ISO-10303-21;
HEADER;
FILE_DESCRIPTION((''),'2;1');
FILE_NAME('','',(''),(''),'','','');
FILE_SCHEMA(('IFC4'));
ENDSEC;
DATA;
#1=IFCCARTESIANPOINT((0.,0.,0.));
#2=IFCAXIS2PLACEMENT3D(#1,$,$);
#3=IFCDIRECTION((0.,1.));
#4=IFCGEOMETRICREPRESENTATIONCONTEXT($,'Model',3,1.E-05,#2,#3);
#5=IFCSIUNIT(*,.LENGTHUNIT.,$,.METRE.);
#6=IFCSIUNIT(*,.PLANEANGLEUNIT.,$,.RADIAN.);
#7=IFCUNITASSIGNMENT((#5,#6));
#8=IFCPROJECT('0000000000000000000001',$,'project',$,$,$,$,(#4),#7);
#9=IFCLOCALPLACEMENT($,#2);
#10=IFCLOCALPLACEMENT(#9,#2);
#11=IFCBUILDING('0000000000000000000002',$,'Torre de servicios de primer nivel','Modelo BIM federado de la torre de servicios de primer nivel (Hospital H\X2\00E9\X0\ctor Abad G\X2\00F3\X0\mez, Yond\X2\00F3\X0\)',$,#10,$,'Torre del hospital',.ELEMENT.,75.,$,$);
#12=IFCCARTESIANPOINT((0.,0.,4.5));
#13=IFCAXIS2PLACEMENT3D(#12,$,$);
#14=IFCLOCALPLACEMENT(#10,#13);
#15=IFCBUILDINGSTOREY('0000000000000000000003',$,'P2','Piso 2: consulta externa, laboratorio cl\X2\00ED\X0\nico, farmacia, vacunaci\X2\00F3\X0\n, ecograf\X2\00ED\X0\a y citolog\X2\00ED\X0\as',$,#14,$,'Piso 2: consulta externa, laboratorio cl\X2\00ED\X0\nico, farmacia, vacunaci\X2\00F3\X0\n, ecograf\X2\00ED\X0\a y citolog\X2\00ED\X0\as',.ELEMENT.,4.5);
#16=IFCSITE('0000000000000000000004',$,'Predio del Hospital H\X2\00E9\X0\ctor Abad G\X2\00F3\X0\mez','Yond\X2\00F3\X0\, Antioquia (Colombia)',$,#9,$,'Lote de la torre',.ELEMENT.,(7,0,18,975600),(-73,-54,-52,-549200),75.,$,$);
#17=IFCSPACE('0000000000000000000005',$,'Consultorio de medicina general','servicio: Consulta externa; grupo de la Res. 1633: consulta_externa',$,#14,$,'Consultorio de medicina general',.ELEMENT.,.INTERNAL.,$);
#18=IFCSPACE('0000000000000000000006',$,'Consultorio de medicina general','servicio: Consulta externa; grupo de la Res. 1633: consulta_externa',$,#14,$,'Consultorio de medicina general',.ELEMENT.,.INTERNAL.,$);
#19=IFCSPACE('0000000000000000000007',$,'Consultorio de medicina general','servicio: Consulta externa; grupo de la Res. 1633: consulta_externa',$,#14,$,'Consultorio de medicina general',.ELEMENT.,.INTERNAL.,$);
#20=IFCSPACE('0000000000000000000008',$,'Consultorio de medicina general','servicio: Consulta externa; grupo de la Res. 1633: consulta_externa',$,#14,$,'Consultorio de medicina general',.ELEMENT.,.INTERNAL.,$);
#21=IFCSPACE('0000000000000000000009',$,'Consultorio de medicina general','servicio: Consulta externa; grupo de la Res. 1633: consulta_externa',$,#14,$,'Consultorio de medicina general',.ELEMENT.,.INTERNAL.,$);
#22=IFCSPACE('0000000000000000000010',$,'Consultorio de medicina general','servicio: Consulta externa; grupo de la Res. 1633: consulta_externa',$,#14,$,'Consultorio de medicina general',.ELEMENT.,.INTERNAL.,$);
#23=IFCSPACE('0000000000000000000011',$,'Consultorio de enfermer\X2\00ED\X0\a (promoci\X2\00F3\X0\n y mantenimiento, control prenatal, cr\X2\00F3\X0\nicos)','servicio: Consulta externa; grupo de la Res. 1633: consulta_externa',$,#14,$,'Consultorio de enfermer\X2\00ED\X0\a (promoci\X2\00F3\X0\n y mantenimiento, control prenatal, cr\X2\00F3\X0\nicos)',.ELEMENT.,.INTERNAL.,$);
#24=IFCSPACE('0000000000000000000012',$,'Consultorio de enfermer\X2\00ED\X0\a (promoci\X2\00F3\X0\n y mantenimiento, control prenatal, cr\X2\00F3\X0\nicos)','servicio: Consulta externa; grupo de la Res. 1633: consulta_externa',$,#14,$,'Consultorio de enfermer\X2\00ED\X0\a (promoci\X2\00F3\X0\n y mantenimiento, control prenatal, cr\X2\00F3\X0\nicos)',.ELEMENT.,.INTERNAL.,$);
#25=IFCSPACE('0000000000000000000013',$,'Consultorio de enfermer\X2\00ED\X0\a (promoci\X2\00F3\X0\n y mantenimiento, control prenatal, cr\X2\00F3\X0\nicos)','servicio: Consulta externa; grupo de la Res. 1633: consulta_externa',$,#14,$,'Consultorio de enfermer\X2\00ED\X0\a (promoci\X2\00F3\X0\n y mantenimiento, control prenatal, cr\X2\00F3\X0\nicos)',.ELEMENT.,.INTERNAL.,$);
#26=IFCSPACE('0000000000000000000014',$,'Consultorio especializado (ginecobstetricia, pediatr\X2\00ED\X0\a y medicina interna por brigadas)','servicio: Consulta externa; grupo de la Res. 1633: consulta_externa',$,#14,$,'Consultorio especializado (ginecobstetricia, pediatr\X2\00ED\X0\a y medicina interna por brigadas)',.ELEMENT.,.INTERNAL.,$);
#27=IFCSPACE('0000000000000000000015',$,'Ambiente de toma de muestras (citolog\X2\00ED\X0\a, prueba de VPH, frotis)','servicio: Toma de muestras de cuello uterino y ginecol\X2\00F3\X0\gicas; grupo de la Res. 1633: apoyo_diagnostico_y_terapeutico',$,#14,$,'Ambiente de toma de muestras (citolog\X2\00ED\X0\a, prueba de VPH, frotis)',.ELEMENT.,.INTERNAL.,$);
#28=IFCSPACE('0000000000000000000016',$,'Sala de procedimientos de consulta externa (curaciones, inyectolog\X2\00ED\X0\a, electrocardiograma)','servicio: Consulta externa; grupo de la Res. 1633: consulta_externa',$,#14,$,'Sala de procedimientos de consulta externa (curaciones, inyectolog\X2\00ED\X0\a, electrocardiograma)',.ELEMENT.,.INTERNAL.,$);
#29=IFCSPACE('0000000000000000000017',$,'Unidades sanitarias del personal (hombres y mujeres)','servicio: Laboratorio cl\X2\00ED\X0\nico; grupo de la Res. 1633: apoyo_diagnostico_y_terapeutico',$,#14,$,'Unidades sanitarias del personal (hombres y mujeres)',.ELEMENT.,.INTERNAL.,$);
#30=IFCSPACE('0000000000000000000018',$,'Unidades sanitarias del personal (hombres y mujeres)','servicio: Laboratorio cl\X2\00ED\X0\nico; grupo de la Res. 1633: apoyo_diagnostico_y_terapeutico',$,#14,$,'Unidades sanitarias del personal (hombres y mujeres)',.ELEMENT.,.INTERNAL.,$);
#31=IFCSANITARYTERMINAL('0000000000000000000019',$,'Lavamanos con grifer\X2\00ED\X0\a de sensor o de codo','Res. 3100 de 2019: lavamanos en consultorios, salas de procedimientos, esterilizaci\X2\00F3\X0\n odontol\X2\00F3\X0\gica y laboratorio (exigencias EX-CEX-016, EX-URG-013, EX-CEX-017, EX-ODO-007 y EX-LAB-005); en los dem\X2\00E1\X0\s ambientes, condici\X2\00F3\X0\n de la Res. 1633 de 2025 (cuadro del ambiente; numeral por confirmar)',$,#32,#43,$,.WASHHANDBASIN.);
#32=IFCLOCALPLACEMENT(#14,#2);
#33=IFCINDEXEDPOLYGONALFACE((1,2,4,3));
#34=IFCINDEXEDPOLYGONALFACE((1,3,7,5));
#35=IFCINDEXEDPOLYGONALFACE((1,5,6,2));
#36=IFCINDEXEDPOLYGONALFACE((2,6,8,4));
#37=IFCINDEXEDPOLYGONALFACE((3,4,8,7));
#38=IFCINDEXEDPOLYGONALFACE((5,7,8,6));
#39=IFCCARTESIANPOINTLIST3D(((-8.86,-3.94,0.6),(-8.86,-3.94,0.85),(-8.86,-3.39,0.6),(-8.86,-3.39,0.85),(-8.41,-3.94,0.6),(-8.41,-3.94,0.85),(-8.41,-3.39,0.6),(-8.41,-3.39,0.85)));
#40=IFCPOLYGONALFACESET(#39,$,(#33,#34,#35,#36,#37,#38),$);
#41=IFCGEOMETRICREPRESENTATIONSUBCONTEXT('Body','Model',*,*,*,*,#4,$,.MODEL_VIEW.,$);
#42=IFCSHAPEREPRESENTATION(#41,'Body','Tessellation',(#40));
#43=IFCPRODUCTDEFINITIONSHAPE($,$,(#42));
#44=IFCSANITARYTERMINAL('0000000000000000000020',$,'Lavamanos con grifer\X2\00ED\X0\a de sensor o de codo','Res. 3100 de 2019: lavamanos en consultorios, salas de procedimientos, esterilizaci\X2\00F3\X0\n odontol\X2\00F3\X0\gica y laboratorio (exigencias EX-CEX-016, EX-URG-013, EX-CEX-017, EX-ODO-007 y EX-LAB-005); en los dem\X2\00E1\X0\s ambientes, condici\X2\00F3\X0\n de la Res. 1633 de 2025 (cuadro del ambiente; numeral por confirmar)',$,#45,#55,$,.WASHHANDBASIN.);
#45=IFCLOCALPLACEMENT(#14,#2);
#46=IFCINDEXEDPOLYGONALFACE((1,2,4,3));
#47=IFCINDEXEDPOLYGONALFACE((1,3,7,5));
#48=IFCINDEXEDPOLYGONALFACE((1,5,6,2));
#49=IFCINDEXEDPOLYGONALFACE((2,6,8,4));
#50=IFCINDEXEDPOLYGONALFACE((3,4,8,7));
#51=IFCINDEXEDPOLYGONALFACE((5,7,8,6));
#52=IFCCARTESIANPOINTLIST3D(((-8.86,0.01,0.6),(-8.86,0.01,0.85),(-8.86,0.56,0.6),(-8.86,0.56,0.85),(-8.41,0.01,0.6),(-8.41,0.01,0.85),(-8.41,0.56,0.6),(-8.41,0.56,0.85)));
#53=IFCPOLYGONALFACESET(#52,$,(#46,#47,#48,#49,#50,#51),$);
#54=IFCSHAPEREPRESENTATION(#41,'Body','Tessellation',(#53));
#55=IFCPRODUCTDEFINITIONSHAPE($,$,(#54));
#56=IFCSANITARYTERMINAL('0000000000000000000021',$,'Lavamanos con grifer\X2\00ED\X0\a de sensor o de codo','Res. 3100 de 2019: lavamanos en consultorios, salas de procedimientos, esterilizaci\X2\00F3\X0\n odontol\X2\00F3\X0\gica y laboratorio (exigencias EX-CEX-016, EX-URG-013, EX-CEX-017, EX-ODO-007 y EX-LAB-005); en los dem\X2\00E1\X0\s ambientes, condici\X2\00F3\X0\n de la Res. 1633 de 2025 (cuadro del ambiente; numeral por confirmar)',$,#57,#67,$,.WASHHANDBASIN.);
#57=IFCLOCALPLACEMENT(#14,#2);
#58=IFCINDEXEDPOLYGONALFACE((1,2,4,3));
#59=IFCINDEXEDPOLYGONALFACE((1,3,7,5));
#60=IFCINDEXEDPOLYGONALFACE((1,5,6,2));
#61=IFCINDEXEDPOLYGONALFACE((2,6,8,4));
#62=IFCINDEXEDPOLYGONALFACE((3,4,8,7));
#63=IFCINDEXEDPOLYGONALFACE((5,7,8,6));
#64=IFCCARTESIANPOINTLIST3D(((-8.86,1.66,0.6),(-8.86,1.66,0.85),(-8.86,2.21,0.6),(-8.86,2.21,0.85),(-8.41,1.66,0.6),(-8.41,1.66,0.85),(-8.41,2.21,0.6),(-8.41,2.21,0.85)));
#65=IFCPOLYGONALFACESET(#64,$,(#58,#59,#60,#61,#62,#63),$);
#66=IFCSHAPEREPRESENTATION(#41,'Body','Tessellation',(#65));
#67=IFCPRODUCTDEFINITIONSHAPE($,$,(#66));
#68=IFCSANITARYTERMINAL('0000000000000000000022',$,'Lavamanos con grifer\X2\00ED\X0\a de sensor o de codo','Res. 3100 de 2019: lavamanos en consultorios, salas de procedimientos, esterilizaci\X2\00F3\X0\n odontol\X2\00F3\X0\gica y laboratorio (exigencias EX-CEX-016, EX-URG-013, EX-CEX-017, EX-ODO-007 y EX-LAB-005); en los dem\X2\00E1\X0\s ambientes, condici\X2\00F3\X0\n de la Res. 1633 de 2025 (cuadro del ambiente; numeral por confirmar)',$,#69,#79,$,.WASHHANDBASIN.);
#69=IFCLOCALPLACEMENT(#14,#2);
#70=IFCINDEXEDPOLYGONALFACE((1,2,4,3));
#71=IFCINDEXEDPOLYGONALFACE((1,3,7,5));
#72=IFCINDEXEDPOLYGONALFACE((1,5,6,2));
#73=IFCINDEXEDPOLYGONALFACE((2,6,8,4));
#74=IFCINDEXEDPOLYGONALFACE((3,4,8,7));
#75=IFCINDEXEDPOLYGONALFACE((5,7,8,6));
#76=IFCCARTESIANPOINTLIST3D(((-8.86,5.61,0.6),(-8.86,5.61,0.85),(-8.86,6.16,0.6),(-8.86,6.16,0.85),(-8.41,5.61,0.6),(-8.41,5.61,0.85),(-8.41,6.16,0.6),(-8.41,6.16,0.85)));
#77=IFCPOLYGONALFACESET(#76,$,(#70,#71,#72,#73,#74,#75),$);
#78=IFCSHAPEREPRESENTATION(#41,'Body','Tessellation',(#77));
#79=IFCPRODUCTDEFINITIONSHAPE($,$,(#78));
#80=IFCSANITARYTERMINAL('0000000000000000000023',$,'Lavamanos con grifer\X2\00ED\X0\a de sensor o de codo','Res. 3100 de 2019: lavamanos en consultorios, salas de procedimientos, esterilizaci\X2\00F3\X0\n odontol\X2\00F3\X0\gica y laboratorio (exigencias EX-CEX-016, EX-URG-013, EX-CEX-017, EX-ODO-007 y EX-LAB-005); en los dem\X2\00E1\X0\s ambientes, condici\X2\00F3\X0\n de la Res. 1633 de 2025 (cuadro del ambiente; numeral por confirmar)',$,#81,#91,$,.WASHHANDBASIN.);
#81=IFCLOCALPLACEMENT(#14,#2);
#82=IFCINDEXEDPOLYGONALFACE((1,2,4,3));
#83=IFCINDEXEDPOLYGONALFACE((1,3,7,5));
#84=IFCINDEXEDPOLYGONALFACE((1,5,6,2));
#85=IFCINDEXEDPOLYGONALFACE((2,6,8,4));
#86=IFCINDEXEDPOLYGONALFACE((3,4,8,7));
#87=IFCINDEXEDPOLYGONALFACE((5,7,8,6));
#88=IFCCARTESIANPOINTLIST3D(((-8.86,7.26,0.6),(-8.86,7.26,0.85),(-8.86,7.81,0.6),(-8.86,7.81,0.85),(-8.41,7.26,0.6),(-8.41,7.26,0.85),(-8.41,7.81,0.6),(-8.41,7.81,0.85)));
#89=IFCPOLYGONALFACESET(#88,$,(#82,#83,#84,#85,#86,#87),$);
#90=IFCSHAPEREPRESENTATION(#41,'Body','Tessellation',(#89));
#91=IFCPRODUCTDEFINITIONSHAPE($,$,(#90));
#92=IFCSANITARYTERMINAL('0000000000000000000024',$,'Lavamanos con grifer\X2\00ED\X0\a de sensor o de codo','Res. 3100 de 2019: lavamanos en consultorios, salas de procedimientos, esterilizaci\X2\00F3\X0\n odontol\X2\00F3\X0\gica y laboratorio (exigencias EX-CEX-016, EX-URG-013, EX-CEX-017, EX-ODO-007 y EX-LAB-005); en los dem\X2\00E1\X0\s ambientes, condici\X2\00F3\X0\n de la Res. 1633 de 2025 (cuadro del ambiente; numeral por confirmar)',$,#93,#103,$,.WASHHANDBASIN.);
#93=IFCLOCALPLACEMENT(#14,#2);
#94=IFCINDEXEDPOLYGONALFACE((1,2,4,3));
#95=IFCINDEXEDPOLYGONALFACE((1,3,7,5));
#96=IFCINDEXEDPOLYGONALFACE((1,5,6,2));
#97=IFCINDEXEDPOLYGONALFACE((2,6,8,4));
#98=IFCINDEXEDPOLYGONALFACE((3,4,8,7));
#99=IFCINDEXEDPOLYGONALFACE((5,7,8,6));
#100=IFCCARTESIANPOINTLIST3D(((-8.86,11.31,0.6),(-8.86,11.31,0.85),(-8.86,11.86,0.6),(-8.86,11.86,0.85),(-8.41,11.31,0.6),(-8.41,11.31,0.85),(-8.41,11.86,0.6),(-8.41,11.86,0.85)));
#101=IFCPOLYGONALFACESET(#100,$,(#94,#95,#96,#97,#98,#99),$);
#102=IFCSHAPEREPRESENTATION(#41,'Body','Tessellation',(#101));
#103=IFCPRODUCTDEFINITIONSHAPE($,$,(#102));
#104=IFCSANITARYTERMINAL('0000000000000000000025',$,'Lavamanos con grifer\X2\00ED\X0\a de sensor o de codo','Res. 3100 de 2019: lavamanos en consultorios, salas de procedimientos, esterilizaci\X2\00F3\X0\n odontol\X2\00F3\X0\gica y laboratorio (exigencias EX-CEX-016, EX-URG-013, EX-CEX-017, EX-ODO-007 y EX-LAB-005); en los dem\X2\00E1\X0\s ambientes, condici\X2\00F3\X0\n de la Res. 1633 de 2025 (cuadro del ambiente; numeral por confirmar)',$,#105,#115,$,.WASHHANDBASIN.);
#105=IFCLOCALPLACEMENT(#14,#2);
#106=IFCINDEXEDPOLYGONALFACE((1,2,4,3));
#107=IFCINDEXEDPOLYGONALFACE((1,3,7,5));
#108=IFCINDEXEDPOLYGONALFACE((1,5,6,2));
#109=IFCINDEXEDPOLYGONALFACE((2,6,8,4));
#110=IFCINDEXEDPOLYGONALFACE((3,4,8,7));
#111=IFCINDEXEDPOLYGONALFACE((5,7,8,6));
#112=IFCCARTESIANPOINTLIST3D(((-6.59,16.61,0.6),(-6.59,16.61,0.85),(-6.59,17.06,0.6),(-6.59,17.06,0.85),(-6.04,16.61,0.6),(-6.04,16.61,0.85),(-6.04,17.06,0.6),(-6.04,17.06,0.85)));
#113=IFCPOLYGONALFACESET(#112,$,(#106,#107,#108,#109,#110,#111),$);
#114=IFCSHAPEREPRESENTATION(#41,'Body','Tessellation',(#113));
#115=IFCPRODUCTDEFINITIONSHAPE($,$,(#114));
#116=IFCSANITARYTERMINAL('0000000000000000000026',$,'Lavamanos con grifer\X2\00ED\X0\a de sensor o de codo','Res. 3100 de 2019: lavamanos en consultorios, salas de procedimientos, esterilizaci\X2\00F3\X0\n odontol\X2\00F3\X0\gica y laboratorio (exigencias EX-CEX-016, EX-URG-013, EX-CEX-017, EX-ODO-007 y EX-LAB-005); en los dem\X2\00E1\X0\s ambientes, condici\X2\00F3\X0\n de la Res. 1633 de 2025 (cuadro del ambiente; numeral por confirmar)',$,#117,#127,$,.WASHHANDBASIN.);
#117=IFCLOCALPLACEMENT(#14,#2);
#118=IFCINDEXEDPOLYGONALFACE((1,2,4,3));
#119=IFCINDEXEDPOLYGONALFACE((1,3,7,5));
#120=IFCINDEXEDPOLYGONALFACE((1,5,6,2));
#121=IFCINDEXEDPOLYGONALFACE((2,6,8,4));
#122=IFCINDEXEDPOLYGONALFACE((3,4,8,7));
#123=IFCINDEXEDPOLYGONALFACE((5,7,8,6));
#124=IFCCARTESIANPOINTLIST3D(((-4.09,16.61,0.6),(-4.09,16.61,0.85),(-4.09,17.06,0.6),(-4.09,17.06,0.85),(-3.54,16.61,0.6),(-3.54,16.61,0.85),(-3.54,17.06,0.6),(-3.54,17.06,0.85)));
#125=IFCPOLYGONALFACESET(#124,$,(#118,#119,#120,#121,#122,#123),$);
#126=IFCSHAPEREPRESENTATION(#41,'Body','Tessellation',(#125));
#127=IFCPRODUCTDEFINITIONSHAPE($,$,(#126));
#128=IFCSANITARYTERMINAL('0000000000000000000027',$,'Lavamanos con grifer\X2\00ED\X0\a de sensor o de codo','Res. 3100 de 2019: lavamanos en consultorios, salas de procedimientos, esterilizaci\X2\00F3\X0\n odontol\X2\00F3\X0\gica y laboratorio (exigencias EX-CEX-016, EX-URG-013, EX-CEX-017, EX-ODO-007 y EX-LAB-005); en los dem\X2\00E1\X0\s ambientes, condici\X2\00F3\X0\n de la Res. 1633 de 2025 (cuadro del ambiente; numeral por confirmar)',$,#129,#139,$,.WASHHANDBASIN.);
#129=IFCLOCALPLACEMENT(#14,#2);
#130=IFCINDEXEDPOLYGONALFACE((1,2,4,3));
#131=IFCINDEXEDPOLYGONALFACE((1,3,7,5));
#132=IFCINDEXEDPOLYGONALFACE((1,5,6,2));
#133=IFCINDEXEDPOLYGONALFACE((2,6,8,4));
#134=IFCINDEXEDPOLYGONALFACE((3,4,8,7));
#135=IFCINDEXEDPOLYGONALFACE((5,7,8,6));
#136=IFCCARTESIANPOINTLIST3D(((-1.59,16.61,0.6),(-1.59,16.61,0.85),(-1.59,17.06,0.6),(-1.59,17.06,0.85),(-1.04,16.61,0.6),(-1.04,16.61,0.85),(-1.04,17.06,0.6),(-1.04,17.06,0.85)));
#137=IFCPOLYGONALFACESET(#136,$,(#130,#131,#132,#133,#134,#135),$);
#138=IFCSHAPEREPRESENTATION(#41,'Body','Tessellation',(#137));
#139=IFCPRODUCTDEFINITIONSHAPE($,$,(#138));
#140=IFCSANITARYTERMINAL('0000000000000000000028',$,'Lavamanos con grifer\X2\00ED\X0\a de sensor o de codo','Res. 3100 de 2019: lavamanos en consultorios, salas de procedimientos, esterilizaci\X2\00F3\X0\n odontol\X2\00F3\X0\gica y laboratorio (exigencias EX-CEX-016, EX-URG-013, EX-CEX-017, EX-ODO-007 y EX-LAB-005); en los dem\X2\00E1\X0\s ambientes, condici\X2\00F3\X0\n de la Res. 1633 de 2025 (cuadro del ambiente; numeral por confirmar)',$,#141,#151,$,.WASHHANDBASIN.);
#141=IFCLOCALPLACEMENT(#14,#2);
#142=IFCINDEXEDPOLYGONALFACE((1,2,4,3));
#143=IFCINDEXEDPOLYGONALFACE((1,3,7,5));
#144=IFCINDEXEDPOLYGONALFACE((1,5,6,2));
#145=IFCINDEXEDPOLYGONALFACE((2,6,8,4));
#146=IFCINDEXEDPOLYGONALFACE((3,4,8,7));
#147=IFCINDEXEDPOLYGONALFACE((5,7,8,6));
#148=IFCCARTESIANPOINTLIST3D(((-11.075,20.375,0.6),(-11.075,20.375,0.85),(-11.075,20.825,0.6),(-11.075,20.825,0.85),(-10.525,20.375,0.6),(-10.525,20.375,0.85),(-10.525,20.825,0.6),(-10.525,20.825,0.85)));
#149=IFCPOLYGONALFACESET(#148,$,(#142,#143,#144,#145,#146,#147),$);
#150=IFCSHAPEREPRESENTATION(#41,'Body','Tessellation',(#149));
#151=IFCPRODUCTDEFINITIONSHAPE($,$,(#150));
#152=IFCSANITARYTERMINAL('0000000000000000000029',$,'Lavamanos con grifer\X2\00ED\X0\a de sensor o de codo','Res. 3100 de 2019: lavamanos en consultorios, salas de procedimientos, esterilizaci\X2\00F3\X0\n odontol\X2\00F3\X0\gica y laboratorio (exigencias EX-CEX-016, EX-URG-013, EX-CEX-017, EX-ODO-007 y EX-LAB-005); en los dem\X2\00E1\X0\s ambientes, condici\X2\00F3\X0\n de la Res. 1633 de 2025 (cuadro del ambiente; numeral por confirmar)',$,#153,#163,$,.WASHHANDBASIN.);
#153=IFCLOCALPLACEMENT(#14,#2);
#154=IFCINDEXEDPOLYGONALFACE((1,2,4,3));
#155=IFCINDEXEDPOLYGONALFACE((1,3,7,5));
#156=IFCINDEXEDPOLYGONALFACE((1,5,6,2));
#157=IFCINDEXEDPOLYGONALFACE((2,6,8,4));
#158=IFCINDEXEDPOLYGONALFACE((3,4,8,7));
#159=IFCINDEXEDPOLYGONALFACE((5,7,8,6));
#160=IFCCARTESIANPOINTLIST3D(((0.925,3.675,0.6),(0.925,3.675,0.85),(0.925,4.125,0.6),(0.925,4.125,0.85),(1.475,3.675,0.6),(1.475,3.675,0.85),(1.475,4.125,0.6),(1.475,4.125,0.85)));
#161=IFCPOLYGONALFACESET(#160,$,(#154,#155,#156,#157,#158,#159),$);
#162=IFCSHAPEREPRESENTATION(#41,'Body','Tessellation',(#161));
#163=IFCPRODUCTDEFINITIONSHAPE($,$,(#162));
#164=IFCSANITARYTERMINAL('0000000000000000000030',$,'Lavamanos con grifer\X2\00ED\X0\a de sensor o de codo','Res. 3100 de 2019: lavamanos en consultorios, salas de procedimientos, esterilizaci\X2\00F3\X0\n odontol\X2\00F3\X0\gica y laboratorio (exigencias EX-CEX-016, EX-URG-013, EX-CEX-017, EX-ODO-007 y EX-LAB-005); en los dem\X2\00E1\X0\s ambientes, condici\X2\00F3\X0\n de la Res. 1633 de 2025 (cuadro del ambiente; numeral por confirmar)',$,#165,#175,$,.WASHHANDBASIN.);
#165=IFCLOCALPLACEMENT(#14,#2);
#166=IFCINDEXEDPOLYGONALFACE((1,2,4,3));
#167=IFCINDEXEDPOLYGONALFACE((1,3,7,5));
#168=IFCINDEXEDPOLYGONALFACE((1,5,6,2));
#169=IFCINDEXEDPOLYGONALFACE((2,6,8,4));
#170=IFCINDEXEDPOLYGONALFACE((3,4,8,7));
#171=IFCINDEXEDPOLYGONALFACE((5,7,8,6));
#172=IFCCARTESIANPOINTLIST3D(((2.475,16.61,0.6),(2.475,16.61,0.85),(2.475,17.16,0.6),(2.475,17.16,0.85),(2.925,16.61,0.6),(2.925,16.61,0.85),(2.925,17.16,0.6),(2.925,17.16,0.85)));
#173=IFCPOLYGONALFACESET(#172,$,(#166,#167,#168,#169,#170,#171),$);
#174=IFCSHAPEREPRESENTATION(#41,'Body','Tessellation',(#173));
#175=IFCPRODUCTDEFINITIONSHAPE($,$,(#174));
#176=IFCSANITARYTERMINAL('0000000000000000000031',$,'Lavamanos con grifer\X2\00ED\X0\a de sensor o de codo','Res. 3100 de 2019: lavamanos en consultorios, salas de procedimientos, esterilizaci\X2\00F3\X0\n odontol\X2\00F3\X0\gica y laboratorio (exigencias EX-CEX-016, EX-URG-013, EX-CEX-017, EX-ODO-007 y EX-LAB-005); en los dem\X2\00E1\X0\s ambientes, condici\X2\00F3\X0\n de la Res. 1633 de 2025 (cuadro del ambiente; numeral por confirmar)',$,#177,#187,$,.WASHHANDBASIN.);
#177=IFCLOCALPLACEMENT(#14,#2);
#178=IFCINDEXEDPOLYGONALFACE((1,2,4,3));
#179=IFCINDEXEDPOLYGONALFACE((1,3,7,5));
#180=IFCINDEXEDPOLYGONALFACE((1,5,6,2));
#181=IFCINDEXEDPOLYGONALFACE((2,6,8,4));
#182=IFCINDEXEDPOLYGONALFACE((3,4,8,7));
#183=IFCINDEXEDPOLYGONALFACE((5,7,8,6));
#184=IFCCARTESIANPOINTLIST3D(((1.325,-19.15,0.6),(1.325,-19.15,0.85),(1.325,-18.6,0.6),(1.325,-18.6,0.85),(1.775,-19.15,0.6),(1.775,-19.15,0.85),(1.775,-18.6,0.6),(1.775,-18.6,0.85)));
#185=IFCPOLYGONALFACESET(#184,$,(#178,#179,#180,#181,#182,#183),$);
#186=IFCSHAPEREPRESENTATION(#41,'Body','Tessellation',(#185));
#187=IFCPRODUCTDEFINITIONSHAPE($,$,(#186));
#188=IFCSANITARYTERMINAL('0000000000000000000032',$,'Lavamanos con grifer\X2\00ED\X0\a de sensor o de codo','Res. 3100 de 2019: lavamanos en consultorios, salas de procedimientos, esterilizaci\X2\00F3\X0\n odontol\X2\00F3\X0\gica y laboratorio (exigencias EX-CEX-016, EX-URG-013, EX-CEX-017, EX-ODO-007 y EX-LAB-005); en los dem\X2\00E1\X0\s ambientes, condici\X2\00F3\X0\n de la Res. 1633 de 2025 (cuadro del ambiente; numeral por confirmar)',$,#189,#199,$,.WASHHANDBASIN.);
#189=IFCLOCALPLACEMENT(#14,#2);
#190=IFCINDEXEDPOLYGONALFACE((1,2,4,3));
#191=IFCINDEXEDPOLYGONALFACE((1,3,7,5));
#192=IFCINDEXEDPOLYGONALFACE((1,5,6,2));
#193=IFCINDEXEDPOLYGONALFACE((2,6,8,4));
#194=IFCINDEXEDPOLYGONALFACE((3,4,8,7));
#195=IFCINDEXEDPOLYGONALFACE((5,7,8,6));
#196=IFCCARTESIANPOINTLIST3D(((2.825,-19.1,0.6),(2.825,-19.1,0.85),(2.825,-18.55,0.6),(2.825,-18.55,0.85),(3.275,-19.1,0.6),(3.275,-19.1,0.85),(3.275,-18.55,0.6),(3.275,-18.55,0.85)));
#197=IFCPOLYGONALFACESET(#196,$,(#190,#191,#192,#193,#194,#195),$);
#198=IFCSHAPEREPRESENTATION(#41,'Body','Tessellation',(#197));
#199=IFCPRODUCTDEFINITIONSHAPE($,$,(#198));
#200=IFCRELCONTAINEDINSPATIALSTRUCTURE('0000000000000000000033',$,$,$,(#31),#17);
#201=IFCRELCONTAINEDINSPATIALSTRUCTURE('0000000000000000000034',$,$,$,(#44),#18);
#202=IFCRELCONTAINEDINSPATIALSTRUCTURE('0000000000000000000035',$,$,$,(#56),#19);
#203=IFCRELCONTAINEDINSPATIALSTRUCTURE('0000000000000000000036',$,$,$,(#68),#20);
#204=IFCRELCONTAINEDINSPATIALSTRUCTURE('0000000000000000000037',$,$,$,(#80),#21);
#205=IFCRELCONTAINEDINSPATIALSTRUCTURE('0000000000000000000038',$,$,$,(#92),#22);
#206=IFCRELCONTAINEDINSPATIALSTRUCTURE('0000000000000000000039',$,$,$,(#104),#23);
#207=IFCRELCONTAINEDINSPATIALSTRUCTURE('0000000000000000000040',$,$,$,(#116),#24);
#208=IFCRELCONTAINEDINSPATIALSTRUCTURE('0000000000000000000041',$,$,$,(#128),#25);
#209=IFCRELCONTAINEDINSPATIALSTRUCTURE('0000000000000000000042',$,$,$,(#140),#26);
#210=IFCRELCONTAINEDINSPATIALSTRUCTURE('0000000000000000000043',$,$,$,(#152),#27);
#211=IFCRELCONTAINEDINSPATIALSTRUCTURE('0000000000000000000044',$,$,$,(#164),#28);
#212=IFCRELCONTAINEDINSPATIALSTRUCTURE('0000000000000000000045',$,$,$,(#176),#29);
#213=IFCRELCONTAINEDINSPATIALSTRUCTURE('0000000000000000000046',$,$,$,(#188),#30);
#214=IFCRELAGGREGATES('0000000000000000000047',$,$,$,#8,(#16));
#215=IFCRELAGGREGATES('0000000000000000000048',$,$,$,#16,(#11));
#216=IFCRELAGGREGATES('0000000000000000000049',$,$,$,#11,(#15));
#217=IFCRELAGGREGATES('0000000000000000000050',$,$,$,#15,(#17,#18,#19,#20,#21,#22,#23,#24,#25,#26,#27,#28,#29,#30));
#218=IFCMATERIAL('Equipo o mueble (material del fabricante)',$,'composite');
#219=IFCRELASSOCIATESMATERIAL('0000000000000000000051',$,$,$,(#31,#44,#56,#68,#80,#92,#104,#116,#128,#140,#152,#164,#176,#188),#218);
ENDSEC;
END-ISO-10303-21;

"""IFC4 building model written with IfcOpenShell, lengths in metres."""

from ifc_helpers import new_model, si_unit, direction, frame, origin, place, context, subcontext, project, spatial, rectangle, extrude, material, element, save


model = new_model("IFC4")

# Units and contexts
model_context = context("Model", 3, precision=1e-05, world=origin(), true_north=direction((0.0, 1.0)))
body_context = subcontext(model_context, "Body", "Model", "MODEL_VIEW")
ifc_project = project(units=[si_unit("LENGTHUNIT", "METRE"), si_unit("PLANEANGLEUNIT", "RADIAN")], contexts=[model_context])

# Site, building, storey
site_placement = place(None, origin())
site = spatial("IfcSite", under=ifc_project, at=site_placement, Name="Predio del Hospital Héctor Abad Gómez", Description="Yondó, Antioquia (Colombia)", LongName="Lote de la torre", CompositionType="ELEMENT", RefLatitude=(7, 0, 18, 975600), RefLongitude=(-73, -54, -52, -549200), RefElevation=75.0)
building_placement = place(site_placement, origin())
building = spatial("IfcBuilding", under=site, at=building_placement, Name="Torre de servicios de primer nivel", Description="Modelo BIM federado de la torre de servicios de primer nivel (Hospital Héctor Abad Gómez, Yondó)", LongName="Torre del hospital", CompositionType="ELEMENT", ElevationOfRefHeight=75.0)
placement = place(building_placement, frame((0.0, 0.0, 4.5)))
storey = spatial("IfcBuildingStorey", under=building, at=placement, Name="P2", Description="Piso 2: consulta externa, laboratorio clínico, farmacia, vacunación, ecografía y citologías", LongName="Piso 2: consulta externa, laboratorio clínico, farmacia, vacunación, ecografía y citologías", CompositionType="ELEMENT", Elevation=4.5)

# Shared definitions
ifc_material = material(Name="Equipo o mueble (material del fabricante)", Category="composite")

# Shared definitions
space_1 = spatial("IfcSpace", under=storey, at=placement, Name="Consultorio de medicina general", Description="servicio: Consulta externa; grupo de la Res. 1633: consulta_externa", LongName="Consultorio de medicina general", CompositionType="ELEMENT", PredefinedType="INTERNAL")

# Sanitary terminal
element("IfcSanitaryTerminal", 1, at=placement, inside=space_1, material=ifc_material, Name="Lavamanos con grifería de sensor o de codo", Description="Res. 3100 de 2019: lavamanos en consultorios, salas de procedimientos, esterilización odontológica y laboratorio (exigencias EX-CEX-016, EX-URG-013, EX-CEX-017, EX-ODO-007 y EX-LAB-005); en los demás ambientes, condición de la Res. 1633 de 2025 (cuadro del ambiente; numeral por confirmar)", PredefinedType="WASHHANDBASIN", context=body_context, shape_type="SweptSolid", body=[
    extrude(rectangle(XDim=0.55, YDim=0.45), frame((-8.635, -3.665, 0.6), z_axis=(0.0, 0.0, 1.0), x_axis=(0.0, 1.0, 0.0)), (0.0, 0.0, 1.0), 0.25),
])

# Shared definitions
space_2 = spatial("IfcSpace", under=storey, at=placement, Name="Consultorio de medicina general", Description="servicio: Consulta externa; grupo de la Res. 1633: consulta_externa", LongName="Consultorio de medicina general", CompositionType="ELEMENT", PredefinedType="INTERNAL")

# Sanitary terminal
element("IfcSanitaryTerminal", 2, at=placement, inside=space_2, material=ifc_material, Name="Lavamanos con grifería de sensor o de codo", Description="Res. 3100 de 2019: lavamanos en consultorios, salas de procedimientos, esterilización odontológica y laboratorio (exigencias EX-CEX-016, EX-URG-013, EX-CEX-017, EX-ODO-007 y EX-LAB-005); en los demás ambientes, condición de la Res. 1633 de 2025 (cuadro del ambiente; numeral por confirmar)", PredefinedType="WASHHANDBASIN", context=body_context, shape_type="SweptSolid", body=[
    extrude(rectangle(XDim=0.55, YDim=0.45), frame((-8.635, 0.285, 0.6), z_axis=(0.0, 0.0, 1.0), x_axis=(0.0, 1.0, 0.0)), (0.0, 0.0, 1.0), 0.25),
])

# Shared definitions
space_3 = spatial("IfcSpace", under=storey, at=placement, Name="Consultorio de medicina general", Description="servicio: Consulta externa; grupo de la Res. 1633: consulta_externa", LongName="Consultorio de medicina general", CompositionType="ELEMENT", PredefinedType="INTERNAL")

# Sanitary terminal
element("IfcSanitaryTerminal", 3, at=placement, inside=space_3, material=ifc_material, Name="Lavamanos con grifería de sensor o de codo", Description="Res. 3100 de 2019: lavamanos en consultorios, salas de procedimientos, esterilización odontológica y laboratorio (exigencias EX-CEX-016, EX-URG-013, EX-CEX-017, EX-ODO-007 y EX-LAB-005); en los demás ambientes, condición de la Res. 1633 de 2025 (cuadro del ambiente; numeral por confirmar)", PredefinedType="WASHHANDBASIN", context=body_context, shape_type="SweptSolid", body=[
    extrude(rectangle(XDim=0.55, YDim=0.45), frame((-8.635, 1.935, 0.6), z_axis=(0.0, 0.0, 1.0), x_axis=(0.0, 1.0, 0.0)), (0.0, 0.0, 1.0), 0.25),
])

# Shared definitions
space_4 = spatial("IfcSpace", under=storey, at=placement, Name="Consultorio de medicina general", Description="servicio: Consulta externa; grupo de la Res. 1633: consulta_externa", LongName="Consultorio de medicina general", CompositionType="ELEMENT", PredefinedType="INTERNAL")

# Sanitary terminal
element("IfcSanitaryTerminal", 4, at=placement, inside=space_4, material=ifc_material, Name="Lavamanos con grifería de sensor o de codo", Description="Res. 3100 de 2019: lavamanos en consultorios, salas de procedimientos, esterilización odontológica y laboratorio (exigencias EX-CEX-016, EX-URG-013, EX-CEX-017, EX-ODO-007 y EX-LAB-005); en los demás ambientes, condición de la Res. 1633 de 2025 (cuadro del ambiente; numeral por confirmar)", PredefinedType="WASHHANDBASIN", context=body_context, shape_type="SweptSolid", body=[
    extrude(rectangle(XDim=0.55, YDim=0.45), frame((-8.635, 5.885, 0.6), z_axis=(0.0, 0.0, 1.0), x_axis=(0.0, 1.0, 0.0)), (0.0, 0.0, 1.0), 0.25),
])

# Shared definitions
space_5 = spatial("IfcSpace", under=storey, at=placement, Name="Consultorio de medicina general", Description="servicio: Consulta externa; grupo de la Res. 1633: consulta_externa", LongName="Consultorio de medicina general", CompositionType="ELEMENT", PredefinedType="INTERNAL")

# Sanitary terminal
element("IfcSanitaryTerminal", 5, at=placement, inside=space_5, material=ifc_material, Name="Lavamanos con grifería de sensor o de codo", Description="Res. 3100 de 2019: lavamanos en consultorios, salas de procedimientos, esterilización odontológica y laboratorio (exigencias EX-CEX-016, EX-URG-013, EX-CEX-017, EX-ODO-007 y EX-LAB-005); en los demás ambientes, condición de la Res. 1633 de 2025 (cuadro del ambiente; numeral por confirmar)", PredefinedType="WASHHANDBASIN", context=body_context, shape_type="SweptSolid", body=[
    extrude(rectangle(XDim=0.55, YDim=0.45), frame((-8.635, 7.535, 0.6), z_axis=(0.0, 0.0, 1.0), x_axis=(0.0, 1.0, 0.0)), (0.0, 0.0, 1.0), 0.25),
])

# Shared definitions
space_6 = spatial("IfcSpace", under=storey, at=placement, Name="Consultorio de medicina general", Description="servicio: Consulta externa; grupo de la Res. 1633: consulta_externa", LongName="Consultorio de medicina general", CompositionType="ELEMENT", PredefinedType="INTERNAL")

# Sanitary terminal
element("IfcSanitaryTerminal", 6, at=placement, inside=space_6, material=ifc_material, Name="Lavamanos con grifería de sensor o de codo", Description="Res. 3100 de 2019: lavamanos en consultorios, salas de procedimientos, esterilización odontológica y laboratorio (exigencias EX-CEX-016, EX-URG-013, EX-CEX-017, EX-ODO-007 y EX-LAB-005); en los demás ambientes, condición de la Res. 1633 de 2025 (cuadro del ambiente; numeral por confirmar)", PredefinedType="WASHHANDBASIN", context=body_context, shape_type="SweptSolid", body=[
    extrude(rectangle(XDim=0.55, YDim=0.45), frame((-8.635, 11.585, 0.6), z_axis=(0.0, 0.0, 1.0), x_axis=(0.0, 1.0, 0.0)), (0.0, 0.0, 1.0), 0.25),
])

# Shared definitions
space_7 = spatial("IfcSpace", under=storey, at=placement, Name="Consultorio de enfermería (promoción y mantenimiento, control prenatal, crónicos)", Description="servicio: Consulta externa; grupo de la Res. 1633: consulta_externa", LongName="Consultorio de enfermería (promoción y mantenimiento, control prenatal, crónicos)", CompositionType="ELEMENT", PredefinedType="INTERNAL")

# Sanitary terminal
element("IfcSanitaryTerminal", 7, at=placement, inside=space_7, material=ifc_material, Name="Lavamanos con grifería de sensor o de codo", Description="Res. 3100 de 2019: lavamanos en consultorios, salas de procedimientos, esterilización odontológica y laboratorio (exigencias EX-CEX-016, EX-URG-013, EX-CEX-017, EX-ODO-007 y EX-LAB-005); en los demás ambientes, condición de la Res. 1633 de 2025 (cuadro del ambiente; numeral por confirmar)", PredefinedType="WASHHANDBASIN", context=body_context, shape_type="SweptSolid", body=[
    extrude(rectangle(XDim=0.55, YDim=0.45), frame((-6.315, 16.835, 0.6)), (0.0, 0.0, 1.0), 0.25),
])

# Shared definitions
space_8 = spatial("IfcSpace", under=storey, at=placement, Name="Consultorio de enfermería (promoción y mantenimiento, control prenatal, crónicos)", Description="servicio: Consulta externa; grupo de la Res. 1633: consulta_externa", LongName="Consultorio de enfermería (promoción y mantenimiento, control prenatal, crónicos)", CompositionType="ELEMENT", PredefinedType="INTERNAL")

# Sanitary terminal
element("IfcSanitaryTerminal", 8, at=placement, inside=space_8, material=ifc_material, Name="Lavamanos con grifería de sensor o de codo", Description="Res. 3100 de 2019: lavamanos en consultorios, salas de procedimientos, esterilización odontológica y laboratorio (exigencias EX-CEX-016, EX-URG-013, EX-CEX-017, EX-ODO-007 y EX-LAB-005); en los demás ambientes, condición de la Res. 1633 de 2025 (cuadro del ambiente; numeral por confirmar)", PredefinedType="WASHHANDBASIN", context=body_context, shape_type="SweptSolid", body=[
    extrude(rectangle(XDim=0.55, YDim=0.45), frame((-3.815, 16.835, 0.6)), (0.0, 0.0, 1.0), 0.25),
])

# Shared definitions
space_9 = spatial("IfcSpace", under=storey, at=placement, Name="Consultorio de enfermería (promoción y mantenimiento, control prenatal, crónicos)", Description="servicio: Consulta externa; grupo de la Res. 1633: consulta_externa", LongName="Consultorio de enfermería (promoción y mantenimiento, control prenatal, crónicos)", CompositionType="ELEMENT", PredefinedType="INTERNAL")

# Sanitary terminal
element("IfcSanitaryTerminal", 9, at=placement, inside=space_9, material=ifc_material, Name="Lavamanos con grifería de sensor o de codo", Description="Res. 3100 de 2019: lavamanos en consultorios, salas de procedimientos, esterilización odontológica y laboratorio (exigencias EX-CEX-016, EX-URG-013, EX-CEX-017, EX-ODO-007 y EX-LAB-005); en los demás ambientes, condición de la Res. 1633 de 2025 (cuadro del ambiente; numeral por confirmar)", PredefinedType="WASHHANDBASIN", context=body_context, shape_type="SweptSolid", body=[
    extrude(rectangle(XDim=0.55, YDim=0.45), frame((-1.315, 16.835, 0.6)), (0.0, 0.0, 1.0), 0.25),
])

# Shared definitions
space_10 = spatial("IfcSpace", under=storey, at=placement, Name="Consultorio especializado (ginecobstetricia, pediatría y medicina interna por brigadas)", Description="servicio: Consulta externa; grupo de la Res. 1633: consulta_externa", LongName="Consultorio especializado (ginecobstetricia, pediatría y medicina interna por brigadas)", CompositionType="ELEMENT", PredefinedType="INTERNAL")

# Sanitary terminal
element("IfcSanitaryTerminal", 10, at=placement, inside=space_10, material=ifc_material, Name="Lavamanos con grifería de sensor o de codo", Description="Res. 3100 de 2019: lavamanos en consultorios, salas de procedimientos, esterilización odontológica y laboratorio (exigencias EX-CEX-016, EX-URG-013, EX-CEX-017, EX-ODO-007 y EX-LAB-005); en los demás ambientes, condición de la Res. 1633 de 2025 (cuadro del ambiente; numeral por confirmar)", PredefinedType="WASHHANDBASIN", context=body_context, shape_type="SweptSolid", body=[
    extrude(rectangle(XDim=0.55, YDim=0.45), frame((-10.8, 20.6, 0.6), z_axis=(0.0, 0.0, 1.0), x_axis=(-1.0, 0.0, 0.0)), (0.0, 0.0, 1.0), 0.25),
])

# Shared definitions
space_11 = spatial("IfcSpace", under=storey, at=placement, Name="Ambiente de toma de muestras (citología, prueba de VPH, frotis)", Description="servicio: Toma de muestras de cuello uterino y ginecológicas; grupo de la Res. 1633: apoyo_diagnostico_y_terapeutico", LongName="Ambiente de toma de muestras (citología, prueba de VPH, frotis)", CompositionType="ELEMENT", PredefinedType="INTERNAL")

# Sanitary terminal
element("IfcSanitaryTerminal", 11, at=placement, inside=space_11, material=ifc_material, Name="Lavamanos con grifería de sensor o de codo", Description="Res. 3100 de 2019: lavamanos en consultorios, salas de procedimientos, esterilización odontológica y laboratorio (exigencias EX-CEX-016, EX-URG-013, EX-CEX-017, EX-ODO-007 y EX-LAB-005); en los demás ambientes, condición de la Res. 1633 de 2025 (cuadro del ambiente; numeral por confirmar)", PredefinedType="WASHHANDBASIN", context=body_context, shape_type="SweptSolid", body=[
    extrude(rectangle(XDim=0.55, YDim=0.45), frame((1.2, 3.9, 0.6)), (0.0, 0.0, 1.0), 0.25),
])

# Shared definitions
space_12 = spatial("IfcSpace", under=storey, at=placement, Name="Sala de procedimientos de consulta externa (curaciones, inyectología, electrocardiograma)", Description="servicio: Consulta externa; grupo de la Res. 1633: consulta_externa", LongName="Sala de procedimientos de consulta externa (curaciones, inyectología, electrocardiograma)", CompositionType="ELEMENT", PredefinedType="INTERNAL")

# Sanitary terminal
element("IfcSanitaryTerminal", 12, at=placement, inside=space_12, material=ifc_material, Name="Lavamanos con grifería de sensor o de codo", Description="Res. 3100 de 2019: lavamanos en consultorios, salas de procedimientos, esterilización odontológica y laboratorio (exigencias EX-CEX-016, EX-URG-013, EX-CEX-017, EX-ODO-007 y EX-LAB-005); en los demás ambientes, condición de la Res. 1633 de 2025 (cuadro del ambiente; numeral por confirmar)", PredefinedType="WASHHANDBASIN", context=body_context, shape_type="SweptSolid", body=[
    extrude(rectangle(XDim=0.55, YDim=0.45), frame((2.7, 16.885, 0.6), z_axis=(0.0, 0.0, 1.0), x_axis=(0.0, 1.0, 0.0)), (0.0, 0.0, 1.0), 0.25),
])

# Shared definitions
space_13 = spatial("IfcSpace", under=storey, at=placement, Name="Unidades sanitarias del personal (hombres y mujeres)", Description="servicio: Laboratorio clínico; grupo de la Res. 1633: apoyo_diagnostico_y_terapeutico", LongName="Unidades sanitarias del personal (hombres y mujeres)", CompositionType="ELEMENT", PredefinedType="INTERNAL")

# Sanitary terminal
element("IfcSanitaryTerminal", 13, at=placement, inside=space_13, material=ifc_material, Name="Lavamanos con grifería de sensor o de codo", Description="Res. 3100 de 2019: lavamanos en consultorios, salas de procedimientos, esterilización odontológica y laboratorio (exigencias EX-CEX-016, EX-URG-013, EX-CEX-017, EX-ODO-007 y EX-LAB-005); en los demás ambientes, condición de la Res. 1633 de 2025 (cuadro del ambiente; numeral por confirmar)", PredefinedType="WASHHANDBASIN", context=body_context, shape_type="SweptSolid", body=[
    extrude(rectangle(XDim=0.55, YDim=0.45), frame((1.55, -18.875, 0.6), z_axis=(0.0, 0.0, 1.0), x_axis=(0.0, 1.0, 0.0)), (0.0, 0.0, 1.0), 0.25),
])

# Shared definitions
space_14 = spatial("IfcSpace", under=storey, at=placement, Name="Unidades sanitarias del personal (hombres y mujeres)", Description="servicio: Laboratorio clínico; grupo de la Res. 1633: apoyo_diagnostico_y_terapeutico", LongName="Unidades sanitarias del personal (hombres y mujeres)", CompositionType="ELEMENT", PredefinedType="INTERNAL")

# Sanitary terminal
element("IfcSanitaryTerminal", 14, at=placement, inside=space_14, material=ifc_material, Name="Lavamanos con grifería de sensor o de codo", Description="Res. 3100 de 2019: lavamanos en consultorios, salas de procedimientos, esterilización odontológica y laboratorio (exigencias EX-CEX-016, EX-URG-013, EX-CEX-017, EX-ODO-007 y EX-LAB-005); en los demás ambientes, condición de la Res. 1633 de 2025 (cuadro del ambiente; numeral por confirmar)", PredefinedType="WASHHANDBASIN", context=body_context, shape_type="SweptSolid", body=[
    extrude(rectangle(XDim=0.55, YDim=0.45), frame((3.05, -18.825, 0.6), z_axis=(0.0, 0.0, 1.0), x_axis=(0.0, 1.0, 0.0)), (0.0, 0.0, 1.0), 0.25),
])

save(model, "model.ifc")
